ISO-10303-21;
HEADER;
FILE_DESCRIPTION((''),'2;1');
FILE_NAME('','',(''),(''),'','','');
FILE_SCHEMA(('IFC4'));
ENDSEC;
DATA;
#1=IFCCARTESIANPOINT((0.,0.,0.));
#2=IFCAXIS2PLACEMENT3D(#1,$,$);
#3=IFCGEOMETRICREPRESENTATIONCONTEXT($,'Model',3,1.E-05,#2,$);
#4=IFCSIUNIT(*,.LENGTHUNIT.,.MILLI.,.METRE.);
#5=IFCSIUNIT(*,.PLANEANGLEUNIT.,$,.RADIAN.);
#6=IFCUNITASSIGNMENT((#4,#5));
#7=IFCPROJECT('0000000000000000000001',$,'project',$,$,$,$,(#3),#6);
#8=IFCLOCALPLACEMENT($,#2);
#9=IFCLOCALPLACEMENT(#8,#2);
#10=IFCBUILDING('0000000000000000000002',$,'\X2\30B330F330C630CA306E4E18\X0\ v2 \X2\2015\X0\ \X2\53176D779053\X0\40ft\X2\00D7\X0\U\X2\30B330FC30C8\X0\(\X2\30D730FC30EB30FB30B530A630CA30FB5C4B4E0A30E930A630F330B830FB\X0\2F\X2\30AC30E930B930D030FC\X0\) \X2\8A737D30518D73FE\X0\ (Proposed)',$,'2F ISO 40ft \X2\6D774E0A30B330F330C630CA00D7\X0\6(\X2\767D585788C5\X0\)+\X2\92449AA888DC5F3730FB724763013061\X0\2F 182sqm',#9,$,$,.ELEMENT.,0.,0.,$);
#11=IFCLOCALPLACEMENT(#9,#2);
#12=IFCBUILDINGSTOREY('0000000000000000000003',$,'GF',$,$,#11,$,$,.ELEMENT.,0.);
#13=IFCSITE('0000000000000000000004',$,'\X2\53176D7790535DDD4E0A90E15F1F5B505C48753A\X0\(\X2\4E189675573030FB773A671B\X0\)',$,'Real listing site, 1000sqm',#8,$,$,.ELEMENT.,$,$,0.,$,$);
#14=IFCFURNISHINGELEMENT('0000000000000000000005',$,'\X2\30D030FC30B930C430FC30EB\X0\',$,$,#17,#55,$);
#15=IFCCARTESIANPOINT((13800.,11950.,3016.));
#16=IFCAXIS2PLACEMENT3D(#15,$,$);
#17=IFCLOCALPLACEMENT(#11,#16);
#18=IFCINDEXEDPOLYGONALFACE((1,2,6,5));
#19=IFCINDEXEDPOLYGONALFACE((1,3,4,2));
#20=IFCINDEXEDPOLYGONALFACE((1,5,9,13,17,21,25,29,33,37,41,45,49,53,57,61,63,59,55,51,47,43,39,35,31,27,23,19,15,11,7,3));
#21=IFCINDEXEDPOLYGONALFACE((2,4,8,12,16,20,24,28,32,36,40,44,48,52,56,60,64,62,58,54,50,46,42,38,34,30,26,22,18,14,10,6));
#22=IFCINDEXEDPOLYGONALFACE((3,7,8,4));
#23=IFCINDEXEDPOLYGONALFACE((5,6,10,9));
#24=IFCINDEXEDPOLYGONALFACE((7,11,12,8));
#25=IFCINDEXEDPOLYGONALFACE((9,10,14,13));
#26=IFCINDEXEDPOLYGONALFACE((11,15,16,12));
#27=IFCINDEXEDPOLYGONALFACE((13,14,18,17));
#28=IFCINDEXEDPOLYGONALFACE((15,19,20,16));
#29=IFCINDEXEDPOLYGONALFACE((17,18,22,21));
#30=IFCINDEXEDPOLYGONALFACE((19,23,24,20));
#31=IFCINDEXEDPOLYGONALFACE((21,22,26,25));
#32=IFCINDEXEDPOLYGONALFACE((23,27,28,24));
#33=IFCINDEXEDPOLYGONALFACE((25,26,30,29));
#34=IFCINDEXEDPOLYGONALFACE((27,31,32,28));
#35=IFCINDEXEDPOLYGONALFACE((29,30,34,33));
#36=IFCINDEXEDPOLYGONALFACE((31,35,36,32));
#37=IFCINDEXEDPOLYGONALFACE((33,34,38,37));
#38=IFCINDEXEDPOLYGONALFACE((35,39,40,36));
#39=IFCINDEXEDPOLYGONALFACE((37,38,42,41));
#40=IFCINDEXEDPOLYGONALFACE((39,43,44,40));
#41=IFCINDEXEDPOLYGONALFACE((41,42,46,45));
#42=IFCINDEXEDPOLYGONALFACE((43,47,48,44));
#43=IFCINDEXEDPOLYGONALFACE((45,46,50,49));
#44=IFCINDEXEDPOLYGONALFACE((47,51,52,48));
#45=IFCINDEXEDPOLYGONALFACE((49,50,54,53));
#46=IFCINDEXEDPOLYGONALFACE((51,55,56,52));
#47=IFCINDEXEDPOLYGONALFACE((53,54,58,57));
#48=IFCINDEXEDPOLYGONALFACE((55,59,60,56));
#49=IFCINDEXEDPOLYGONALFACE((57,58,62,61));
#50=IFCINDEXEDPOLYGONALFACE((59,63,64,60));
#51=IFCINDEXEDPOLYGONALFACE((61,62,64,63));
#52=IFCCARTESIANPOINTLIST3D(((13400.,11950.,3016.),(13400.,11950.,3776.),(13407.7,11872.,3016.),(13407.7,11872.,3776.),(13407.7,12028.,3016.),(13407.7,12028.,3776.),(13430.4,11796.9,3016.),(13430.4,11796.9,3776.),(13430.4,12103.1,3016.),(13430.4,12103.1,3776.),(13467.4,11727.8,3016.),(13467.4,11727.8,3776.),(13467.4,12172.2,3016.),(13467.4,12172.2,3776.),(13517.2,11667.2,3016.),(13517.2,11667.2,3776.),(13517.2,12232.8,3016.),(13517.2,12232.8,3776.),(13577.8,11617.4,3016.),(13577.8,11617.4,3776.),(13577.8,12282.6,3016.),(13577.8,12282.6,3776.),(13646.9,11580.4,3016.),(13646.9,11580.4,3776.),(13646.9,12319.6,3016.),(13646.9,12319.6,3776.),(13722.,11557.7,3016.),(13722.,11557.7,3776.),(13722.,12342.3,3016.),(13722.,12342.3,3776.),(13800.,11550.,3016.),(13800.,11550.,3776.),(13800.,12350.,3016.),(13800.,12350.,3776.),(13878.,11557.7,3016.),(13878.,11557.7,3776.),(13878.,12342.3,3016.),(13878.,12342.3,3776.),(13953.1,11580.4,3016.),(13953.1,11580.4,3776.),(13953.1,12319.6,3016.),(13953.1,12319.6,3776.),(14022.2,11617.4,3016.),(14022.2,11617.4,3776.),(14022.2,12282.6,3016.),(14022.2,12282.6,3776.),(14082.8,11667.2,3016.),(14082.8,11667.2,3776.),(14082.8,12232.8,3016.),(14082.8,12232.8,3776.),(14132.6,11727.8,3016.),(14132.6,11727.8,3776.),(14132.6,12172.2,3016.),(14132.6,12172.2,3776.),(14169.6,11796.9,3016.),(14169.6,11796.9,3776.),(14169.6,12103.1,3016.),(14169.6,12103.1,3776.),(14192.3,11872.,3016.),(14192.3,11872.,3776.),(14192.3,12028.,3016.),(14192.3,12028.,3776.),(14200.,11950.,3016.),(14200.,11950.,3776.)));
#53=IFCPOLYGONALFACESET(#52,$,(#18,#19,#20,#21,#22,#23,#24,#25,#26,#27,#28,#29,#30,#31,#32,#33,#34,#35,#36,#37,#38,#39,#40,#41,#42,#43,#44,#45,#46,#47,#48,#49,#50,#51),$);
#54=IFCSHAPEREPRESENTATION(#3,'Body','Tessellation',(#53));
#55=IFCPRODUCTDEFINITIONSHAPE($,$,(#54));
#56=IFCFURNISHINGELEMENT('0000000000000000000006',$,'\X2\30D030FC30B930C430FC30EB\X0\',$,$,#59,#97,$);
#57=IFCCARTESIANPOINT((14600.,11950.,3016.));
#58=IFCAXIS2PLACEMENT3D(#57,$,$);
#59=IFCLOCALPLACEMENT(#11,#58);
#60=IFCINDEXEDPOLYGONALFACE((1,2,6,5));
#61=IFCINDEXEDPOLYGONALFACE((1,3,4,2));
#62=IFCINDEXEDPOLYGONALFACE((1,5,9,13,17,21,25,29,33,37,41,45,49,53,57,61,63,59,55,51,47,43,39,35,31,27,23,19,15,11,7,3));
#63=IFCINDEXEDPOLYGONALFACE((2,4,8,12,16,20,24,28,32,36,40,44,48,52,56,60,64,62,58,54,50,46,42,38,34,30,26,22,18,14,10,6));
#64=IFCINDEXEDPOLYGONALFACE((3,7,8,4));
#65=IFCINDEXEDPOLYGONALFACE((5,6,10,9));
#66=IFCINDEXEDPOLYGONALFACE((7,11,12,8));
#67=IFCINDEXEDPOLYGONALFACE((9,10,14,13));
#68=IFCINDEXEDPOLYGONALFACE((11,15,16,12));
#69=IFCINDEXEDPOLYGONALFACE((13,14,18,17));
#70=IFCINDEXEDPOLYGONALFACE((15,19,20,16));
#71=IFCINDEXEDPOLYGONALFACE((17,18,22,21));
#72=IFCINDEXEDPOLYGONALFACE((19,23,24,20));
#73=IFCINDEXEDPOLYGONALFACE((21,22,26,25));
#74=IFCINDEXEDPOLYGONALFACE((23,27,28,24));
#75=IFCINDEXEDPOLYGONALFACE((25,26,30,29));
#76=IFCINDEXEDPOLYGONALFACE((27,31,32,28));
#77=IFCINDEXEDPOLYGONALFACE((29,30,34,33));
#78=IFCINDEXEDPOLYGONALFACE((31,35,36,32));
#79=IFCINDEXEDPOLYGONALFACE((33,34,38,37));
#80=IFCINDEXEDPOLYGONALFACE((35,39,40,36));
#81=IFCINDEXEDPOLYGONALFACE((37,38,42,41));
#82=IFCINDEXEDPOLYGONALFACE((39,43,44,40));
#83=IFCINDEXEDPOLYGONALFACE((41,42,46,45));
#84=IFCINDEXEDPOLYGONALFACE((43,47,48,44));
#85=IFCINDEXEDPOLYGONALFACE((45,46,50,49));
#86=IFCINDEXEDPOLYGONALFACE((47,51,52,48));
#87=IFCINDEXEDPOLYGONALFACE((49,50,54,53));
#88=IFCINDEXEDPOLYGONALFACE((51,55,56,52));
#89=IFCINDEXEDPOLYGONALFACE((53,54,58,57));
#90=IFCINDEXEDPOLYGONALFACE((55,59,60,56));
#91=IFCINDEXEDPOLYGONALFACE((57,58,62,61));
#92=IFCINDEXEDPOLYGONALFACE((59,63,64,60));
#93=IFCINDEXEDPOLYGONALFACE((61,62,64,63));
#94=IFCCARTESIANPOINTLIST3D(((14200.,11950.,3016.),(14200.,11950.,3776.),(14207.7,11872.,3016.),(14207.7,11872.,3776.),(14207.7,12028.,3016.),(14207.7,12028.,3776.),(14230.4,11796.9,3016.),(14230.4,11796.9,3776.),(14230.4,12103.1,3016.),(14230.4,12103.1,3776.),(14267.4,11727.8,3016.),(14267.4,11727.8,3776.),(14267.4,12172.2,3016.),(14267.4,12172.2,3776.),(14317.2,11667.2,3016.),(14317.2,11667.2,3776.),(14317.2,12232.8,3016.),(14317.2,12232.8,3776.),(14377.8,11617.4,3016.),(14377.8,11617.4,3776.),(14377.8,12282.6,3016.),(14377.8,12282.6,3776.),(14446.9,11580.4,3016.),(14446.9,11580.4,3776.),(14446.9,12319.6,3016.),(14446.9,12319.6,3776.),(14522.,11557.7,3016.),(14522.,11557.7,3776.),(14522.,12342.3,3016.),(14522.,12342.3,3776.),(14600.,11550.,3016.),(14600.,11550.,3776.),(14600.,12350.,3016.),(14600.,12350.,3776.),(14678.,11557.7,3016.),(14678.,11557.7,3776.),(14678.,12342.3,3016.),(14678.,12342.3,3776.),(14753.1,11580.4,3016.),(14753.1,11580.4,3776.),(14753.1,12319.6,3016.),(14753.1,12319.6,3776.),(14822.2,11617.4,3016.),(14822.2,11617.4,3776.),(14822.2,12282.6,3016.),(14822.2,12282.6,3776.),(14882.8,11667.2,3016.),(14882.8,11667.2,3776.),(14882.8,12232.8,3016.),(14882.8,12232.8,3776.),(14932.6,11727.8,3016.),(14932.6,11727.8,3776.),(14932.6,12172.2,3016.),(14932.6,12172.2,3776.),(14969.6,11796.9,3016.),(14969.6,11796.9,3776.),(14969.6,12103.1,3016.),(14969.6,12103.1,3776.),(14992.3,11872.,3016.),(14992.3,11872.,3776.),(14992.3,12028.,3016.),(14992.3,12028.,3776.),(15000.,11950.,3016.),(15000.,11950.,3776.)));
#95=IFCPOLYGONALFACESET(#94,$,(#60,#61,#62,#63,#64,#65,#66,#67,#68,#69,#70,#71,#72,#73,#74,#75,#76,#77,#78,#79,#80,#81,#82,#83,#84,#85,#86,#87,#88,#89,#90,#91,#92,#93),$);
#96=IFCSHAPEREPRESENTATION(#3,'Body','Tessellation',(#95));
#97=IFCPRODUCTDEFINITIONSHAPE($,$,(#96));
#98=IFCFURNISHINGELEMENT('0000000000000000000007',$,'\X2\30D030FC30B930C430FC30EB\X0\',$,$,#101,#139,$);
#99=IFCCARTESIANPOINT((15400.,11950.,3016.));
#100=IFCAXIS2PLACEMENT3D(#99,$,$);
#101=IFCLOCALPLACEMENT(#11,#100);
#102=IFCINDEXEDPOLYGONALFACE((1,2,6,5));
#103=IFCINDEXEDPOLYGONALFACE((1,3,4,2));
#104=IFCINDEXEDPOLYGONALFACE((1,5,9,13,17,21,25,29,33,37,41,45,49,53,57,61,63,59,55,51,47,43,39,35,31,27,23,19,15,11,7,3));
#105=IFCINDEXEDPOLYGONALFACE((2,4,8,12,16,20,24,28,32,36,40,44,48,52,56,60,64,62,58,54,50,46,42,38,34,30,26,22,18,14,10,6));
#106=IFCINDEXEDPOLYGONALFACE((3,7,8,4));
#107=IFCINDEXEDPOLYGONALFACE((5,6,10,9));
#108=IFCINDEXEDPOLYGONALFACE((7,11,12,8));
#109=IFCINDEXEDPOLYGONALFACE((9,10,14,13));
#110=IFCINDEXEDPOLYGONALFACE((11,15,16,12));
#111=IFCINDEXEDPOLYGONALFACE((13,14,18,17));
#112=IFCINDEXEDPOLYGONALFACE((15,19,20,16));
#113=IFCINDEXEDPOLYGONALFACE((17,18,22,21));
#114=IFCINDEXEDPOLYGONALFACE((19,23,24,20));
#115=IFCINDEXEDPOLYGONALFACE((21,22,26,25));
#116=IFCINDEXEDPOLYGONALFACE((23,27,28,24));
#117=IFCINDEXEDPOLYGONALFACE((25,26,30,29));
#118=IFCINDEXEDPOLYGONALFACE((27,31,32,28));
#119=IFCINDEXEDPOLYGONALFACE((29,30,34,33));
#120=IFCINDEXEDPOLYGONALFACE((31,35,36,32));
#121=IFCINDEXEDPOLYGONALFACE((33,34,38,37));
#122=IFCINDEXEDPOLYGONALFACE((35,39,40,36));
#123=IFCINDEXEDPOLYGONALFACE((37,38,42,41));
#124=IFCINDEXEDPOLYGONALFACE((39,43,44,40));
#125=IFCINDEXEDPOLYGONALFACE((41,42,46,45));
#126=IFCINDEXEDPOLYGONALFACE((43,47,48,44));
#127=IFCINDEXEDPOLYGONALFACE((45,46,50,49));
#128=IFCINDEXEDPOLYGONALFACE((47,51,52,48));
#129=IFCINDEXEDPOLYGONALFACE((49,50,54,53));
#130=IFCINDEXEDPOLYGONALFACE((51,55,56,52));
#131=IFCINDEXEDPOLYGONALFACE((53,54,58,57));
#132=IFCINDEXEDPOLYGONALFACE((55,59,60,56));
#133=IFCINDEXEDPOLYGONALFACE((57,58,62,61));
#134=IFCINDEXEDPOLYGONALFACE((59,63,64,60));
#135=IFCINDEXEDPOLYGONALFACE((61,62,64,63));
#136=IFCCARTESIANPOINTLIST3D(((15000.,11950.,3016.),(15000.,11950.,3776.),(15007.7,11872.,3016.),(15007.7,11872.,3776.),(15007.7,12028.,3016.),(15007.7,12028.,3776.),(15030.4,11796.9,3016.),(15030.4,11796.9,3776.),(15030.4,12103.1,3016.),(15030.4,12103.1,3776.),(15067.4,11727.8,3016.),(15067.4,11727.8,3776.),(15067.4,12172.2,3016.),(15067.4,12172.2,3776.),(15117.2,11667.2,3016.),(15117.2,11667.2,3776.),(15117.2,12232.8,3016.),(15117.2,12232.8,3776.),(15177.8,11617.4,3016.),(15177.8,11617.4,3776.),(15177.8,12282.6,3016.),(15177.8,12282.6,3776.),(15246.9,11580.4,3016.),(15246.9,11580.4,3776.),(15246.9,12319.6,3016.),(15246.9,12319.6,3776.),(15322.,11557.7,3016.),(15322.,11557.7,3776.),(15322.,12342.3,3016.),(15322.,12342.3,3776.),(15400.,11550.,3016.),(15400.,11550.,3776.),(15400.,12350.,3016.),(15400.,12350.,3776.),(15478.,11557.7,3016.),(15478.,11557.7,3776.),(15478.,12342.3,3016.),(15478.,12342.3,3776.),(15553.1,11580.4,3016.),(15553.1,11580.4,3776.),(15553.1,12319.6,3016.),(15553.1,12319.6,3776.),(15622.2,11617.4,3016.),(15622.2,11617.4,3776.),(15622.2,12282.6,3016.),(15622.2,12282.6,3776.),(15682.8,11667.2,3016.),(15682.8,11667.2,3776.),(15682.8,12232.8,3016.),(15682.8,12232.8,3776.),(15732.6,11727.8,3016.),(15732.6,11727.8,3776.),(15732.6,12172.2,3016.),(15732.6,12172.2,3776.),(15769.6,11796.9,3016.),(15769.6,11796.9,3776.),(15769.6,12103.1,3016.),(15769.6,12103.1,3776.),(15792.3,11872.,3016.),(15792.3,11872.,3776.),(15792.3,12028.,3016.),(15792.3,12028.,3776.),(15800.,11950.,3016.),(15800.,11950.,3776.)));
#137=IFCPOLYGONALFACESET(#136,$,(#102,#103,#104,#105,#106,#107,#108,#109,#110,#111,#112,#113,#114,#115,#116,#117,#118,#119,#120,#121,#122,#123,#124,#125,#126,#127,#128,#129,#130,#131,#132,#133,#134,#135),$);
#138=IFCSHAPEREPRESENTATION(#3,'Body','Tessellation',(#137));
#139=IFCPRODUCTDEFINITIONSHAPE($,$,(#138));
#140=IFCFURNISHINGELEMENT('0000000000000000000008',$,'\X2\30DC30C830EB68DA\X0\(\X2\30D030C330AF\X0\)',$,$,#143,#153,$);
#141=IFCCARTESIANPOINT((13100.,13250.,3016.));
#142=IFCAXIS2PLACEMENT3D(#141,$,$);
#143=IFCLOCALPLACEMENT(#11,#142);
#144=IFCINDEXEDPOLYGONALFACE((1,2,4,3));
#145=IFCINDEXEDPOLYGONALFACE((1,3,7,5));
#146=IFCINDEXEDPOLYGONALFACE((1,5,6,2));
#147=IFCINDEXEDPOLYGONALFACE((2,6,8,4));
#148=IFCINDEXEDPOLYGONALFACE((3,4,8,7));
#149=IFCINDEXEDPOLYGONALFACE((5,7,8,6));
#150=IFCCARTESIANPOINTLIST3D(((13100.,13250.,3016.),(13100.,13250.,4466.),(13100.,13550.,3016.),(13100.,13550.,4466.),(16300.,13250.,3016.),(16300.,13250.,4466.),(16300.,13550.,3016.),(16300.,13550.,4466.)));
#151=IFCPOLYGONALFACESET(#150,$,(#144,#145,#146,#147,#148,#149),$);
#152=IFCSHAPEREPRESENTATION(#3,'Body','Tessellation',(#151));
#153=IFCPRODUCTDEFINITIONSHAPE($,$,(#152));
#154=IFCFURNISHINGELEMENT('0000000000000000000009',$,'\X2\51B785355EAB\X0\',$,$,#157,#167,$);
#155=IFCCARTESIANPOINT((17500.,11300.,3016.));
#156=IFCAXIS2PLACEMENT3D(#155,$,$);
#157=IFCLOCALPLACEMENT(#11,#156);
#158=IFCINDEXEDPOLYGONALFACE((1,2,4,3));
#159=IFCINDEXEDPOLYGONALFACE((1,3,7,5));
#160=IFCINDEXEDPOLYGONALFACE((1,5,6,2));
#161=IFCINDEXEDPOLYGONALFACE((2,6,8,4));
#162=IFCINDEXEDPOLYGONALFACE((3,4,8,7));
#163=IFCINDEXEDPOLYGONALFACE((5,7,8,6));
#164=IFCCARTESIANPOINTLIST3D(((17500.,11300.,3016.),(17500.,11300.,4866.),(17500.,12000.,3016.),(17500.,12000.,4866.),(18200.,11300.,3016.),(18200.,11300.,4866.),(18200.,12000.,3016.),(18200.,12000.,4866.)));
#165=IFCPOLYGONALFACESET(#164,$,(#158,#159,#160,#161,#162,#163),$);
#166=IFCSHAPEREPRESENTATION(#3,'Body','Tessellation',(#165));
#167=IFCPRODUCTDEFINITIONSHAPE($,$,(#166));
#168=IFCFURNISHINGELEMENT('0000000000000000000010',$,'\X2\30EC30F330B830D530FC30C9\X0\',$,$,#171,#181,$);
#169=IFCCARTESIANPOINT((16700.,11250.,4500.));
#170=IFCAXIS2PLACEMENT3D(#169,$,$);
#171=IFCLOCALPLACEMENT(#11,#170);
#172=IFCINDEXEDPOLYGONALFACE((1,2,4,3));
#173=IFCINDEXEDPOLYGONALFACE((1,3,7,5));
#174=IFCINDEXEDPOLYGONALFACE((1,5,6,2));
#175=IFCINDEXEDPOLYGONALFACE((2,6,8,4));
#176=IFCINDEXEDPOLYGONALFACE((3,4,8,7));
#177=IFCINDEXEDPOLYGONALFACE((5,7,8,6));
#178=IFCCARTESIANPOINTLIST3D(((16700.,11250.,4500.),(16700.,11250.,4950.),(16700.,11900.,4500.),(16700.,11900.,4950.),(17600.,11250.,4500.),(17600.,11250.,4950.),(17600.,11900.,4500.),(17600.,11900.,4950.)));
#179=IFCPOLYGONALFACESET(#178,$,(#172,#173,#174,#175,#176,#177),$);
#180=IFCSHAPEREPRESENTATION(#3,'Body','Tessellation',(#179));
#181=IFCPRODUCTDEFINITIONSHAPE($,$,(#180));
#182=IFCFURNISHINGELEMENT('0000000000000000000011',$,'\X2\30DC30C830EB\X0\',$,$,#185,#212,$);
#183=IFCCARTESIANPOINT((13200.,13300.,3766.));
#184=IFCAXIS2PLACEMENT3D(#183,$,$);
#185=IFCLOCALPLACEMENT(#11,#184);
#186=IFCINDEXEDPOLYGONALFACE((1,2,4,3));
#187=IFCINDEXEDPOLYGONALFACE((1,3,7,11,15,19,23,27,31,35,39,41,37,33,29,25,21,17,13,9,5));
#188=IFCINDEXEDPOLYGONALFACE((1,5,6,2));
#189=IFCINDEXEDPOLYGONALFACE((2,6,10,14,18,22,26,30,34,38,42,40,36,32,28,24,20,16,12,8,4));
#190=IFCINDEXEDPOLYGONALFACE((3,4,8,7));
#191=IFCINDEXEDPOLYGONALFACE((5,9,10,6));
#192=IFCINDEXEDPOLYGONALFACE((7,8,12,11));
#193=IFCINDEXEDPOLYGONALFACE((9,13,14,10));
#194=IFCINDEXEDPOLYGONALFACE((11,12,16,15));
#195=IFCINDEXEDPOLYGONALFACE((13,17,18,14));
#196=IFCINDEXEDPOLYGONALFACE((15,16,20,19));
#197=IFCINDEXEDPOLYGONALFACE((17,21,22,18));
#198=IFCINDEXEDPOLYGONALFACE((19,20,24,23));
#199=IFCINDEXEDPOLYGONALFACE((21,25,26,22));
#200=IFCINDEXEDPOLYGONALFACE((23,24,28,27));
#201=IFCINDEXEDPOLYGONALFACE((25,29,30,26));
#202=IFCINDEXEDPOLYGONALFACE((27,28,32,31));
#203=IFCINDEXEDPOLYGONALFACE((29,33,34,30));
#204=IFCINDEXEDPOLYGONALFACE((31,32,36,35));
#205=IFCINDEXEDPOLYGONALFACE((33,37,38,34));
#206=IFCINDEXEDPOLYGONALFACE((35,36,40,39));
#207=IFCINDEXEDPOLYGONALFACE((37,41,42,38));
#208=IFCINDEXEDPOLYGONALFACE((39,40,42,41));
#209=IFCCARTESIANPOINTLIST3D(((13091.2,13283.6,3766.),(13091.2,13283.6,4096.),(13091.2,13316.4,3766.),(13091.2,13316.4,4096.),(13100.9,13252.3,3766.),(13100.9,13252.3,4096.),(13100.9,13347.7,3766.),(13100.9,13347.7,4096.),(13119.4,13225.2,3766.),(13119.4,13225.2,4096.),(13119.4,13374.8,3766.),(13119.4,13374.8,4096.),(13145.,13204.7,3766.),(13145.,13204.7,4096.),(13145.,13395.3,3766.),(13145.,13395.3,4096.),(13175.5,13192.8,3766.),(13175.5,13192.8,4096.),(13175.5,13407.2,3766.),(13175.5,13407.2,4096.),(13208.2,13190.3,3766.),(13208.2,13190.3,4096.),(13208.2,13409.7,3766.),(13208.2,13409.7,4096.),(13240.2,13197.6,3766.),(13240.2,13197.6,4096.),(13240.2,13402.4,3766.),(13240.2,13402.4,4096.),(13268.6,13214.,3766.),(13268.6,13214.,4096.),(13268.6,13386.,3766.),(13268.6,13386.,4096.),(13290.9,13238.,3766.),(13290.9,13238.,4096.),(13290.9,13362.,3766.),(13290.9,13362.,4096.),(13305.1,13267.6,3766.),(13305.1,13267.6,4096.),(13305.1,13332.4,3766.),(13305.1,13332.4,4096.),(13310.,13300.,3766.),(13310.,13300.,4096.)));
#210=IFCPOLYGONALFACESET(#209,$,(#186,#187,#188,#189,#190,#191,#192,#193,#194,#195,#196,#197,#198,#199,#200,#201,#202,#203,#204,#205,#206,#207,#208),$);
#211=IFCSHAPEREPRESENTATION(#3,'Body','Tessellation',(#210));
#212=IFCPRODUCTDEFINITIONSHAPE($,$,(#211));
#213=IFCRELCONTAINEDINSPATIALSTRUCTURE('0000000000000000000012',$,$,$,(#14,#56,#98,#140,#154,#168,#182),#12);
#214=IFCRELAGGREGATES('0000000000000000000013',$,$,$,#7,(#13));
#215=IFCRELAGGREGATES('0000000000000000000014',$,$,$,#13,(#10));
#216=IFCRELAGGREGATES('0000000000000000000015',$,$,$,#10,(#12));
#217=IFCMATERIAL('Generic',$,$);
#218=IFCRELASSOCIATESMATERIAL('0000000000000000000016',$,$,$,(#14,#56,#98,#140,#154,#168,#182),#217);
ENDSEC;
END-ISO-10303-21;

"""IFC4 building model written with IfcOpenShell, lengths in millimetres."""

from ifc_helpers import new_model, si_unit, frame, frame_2d, origin, origin_2d, place, context, project, spatial, rectangle, circle, extrude, material, element, save


model = new_model("IFC4")

# Units and contexts
model_context = context("Model", 3, precision=1e-05, world=origin())
ifc_project = project(units=[si_unit("LENGTHUNIT", "METRE", prefix="MILLI"), si_unit("PLANEANGLEUNIT", "RADIAN")], contexts=[model_context])

# Site, building, storey
site_placement = place(None, origin())
site = spatial("IfcSite", under=ifc_project, at=site_placement, Name="北海道川上郡弟子屈町(丘陵地・眺望)", ObjectType="Real listing site, 1000sqm", CompositionType="ELEMENT", RefElevation=0.0)
building_placement = place(site_placement, origin())
building = spatial("IfcBuilding", under=site, at=building_placement, Name="コンテナの丘 v2 ― 北海道40ft×Uコート(プール・サウナ・屋上ラウンジ・2Fガラスバー) 詳細再現 (Proposed)", ObjectType="2F ISO 40ft 海上コンテナ×6(白塗装)+鉄骨補強・片持ち2F 182sqm", CompositionType="ELEMENT", ElevationOfRefHeight=0.0, ElevationOfTerrain=0.0)
storey_placement = place(building_placement, origin())
storey = spatial("IfcBuildingStorey", under=building, at=storey_placement, Name="GF", CompositionType="ELEMENT", Elevation=0.0)

# Shared definitions
ifc_material = material(Name="Generic")

# Furnishing elements
furnishing_1_placement = place(storey_placement, frame((13800.0, 11950.0, 3016.0)))
element("IfcFurnishingElement", 1, at=furnishing_1_placement, inside=storey, material=ifc_material, Name="バースツール", context=model_context, shape_type="SweptSolid", body=[
    extrude(circle(Radius=400.0, at=origin_2d()), frame((13800.0, 11950.0, 3016.0)), (0.0, 0.0, 1.0), 760.0),
])
furnishing_2_placement = place(storey_placement, frame((14600.0, 11950.0, 3016.0)))
element("IfcFurnishingElement", 2, at=furnishing_2_placement, inside=storey, material=ifc_material, Name="バースツール", context=model_context, shape_type="SweptSolid", body=[
    extrude(circle(Radius=400.0, at=origin_2d()), frame((14600.0, 11950.0, 3016.0)), (0.0, 0.0, 1.0), 760.0),
])
furnishing_3_placement = place(storey_placement, frame((15400.0, 11950.0, 3016.0)))
element("IfcFurnishingElement", 3, at=furnishing_3_placement, inside=storey, material=ifc_material, Name="バースツール", context=model_context, shape_type="SweptSolid", body=[
    extrude(circle(Radius=400.0, at=origin_2d()), frame((15400.0, 11950.0, 3016.0)), (0.0, 0.0, 1.0), 760.0),
])
furnishing_4_placement = place(storey_placement, frame((13100.0, 13250.0, 3016.0)))
element("IfcFurnishingElement", 4, at=furnishing_4_placement, inside=storey, material=ifc_material, Name="ボトル棚(バック)", context=model_context, shape_type="SweptSolid", body=[
    extrude(rectangle(XDim=3200.0, YDim=300.0, at=frame_2d((1600.0, 150.0))), frame((13100.0, 13250.0, 3016.0)), (0.0, 0.0, 1.0), 1450.0),
])
furnishing_5_placement = place(storey_placement, frame((17500.0, 11300.0, 3016.0)))
element("IfcFurnishingElement", 5, at=furnishing_5_placement, inside=storey, material=ifc_material, Name="冷蔵庫", context=model_context, shape_type="SweptSolid", body=[
    extrude(rectangle(XDim=700.0, YDim=700.0, at=frame_2d((350.0, 350.0))), frame((17500.0, 11300.0, 3016.0)), (0.0, 0.0, 1.0), 1850.0),
])
furnishing_6_placement = place(storey_placement, frame((16700.0, 11250.0, 4500.0)))
element("IfcFurnishingElement", 6, at=furnishing_6_placement, inside=storey, material=ifc_material, Name="レンジフード", context=model_context, shape_type="SweptSolid", body=[
    extrude(rectangle(XDim=900.0, YDim=650.0, at=frame_2d((450.0, 325.0))), frame((16700.0, 11250.0, 4500.0)), (0.0, 0.0, 1.0), 450.0),
])
furnishing_7_placement = place(storey_placement, frame((13200.0, 13300.0, 3766.0)))
element("IfcFurnishingElement", 7, at=furnishing_7_placement, inside=storey, material=ifc_material, Name="ボトル", context=model_context, shape_type="SweptSolid", body=[
    extrude(circle(Radius=110.0, at=origin_2d()), frame((13200.0, 13300.0, 3766.0)), (0.0, 0.0, 1.0), 330.0),
])

save(model, "model.ifc")
